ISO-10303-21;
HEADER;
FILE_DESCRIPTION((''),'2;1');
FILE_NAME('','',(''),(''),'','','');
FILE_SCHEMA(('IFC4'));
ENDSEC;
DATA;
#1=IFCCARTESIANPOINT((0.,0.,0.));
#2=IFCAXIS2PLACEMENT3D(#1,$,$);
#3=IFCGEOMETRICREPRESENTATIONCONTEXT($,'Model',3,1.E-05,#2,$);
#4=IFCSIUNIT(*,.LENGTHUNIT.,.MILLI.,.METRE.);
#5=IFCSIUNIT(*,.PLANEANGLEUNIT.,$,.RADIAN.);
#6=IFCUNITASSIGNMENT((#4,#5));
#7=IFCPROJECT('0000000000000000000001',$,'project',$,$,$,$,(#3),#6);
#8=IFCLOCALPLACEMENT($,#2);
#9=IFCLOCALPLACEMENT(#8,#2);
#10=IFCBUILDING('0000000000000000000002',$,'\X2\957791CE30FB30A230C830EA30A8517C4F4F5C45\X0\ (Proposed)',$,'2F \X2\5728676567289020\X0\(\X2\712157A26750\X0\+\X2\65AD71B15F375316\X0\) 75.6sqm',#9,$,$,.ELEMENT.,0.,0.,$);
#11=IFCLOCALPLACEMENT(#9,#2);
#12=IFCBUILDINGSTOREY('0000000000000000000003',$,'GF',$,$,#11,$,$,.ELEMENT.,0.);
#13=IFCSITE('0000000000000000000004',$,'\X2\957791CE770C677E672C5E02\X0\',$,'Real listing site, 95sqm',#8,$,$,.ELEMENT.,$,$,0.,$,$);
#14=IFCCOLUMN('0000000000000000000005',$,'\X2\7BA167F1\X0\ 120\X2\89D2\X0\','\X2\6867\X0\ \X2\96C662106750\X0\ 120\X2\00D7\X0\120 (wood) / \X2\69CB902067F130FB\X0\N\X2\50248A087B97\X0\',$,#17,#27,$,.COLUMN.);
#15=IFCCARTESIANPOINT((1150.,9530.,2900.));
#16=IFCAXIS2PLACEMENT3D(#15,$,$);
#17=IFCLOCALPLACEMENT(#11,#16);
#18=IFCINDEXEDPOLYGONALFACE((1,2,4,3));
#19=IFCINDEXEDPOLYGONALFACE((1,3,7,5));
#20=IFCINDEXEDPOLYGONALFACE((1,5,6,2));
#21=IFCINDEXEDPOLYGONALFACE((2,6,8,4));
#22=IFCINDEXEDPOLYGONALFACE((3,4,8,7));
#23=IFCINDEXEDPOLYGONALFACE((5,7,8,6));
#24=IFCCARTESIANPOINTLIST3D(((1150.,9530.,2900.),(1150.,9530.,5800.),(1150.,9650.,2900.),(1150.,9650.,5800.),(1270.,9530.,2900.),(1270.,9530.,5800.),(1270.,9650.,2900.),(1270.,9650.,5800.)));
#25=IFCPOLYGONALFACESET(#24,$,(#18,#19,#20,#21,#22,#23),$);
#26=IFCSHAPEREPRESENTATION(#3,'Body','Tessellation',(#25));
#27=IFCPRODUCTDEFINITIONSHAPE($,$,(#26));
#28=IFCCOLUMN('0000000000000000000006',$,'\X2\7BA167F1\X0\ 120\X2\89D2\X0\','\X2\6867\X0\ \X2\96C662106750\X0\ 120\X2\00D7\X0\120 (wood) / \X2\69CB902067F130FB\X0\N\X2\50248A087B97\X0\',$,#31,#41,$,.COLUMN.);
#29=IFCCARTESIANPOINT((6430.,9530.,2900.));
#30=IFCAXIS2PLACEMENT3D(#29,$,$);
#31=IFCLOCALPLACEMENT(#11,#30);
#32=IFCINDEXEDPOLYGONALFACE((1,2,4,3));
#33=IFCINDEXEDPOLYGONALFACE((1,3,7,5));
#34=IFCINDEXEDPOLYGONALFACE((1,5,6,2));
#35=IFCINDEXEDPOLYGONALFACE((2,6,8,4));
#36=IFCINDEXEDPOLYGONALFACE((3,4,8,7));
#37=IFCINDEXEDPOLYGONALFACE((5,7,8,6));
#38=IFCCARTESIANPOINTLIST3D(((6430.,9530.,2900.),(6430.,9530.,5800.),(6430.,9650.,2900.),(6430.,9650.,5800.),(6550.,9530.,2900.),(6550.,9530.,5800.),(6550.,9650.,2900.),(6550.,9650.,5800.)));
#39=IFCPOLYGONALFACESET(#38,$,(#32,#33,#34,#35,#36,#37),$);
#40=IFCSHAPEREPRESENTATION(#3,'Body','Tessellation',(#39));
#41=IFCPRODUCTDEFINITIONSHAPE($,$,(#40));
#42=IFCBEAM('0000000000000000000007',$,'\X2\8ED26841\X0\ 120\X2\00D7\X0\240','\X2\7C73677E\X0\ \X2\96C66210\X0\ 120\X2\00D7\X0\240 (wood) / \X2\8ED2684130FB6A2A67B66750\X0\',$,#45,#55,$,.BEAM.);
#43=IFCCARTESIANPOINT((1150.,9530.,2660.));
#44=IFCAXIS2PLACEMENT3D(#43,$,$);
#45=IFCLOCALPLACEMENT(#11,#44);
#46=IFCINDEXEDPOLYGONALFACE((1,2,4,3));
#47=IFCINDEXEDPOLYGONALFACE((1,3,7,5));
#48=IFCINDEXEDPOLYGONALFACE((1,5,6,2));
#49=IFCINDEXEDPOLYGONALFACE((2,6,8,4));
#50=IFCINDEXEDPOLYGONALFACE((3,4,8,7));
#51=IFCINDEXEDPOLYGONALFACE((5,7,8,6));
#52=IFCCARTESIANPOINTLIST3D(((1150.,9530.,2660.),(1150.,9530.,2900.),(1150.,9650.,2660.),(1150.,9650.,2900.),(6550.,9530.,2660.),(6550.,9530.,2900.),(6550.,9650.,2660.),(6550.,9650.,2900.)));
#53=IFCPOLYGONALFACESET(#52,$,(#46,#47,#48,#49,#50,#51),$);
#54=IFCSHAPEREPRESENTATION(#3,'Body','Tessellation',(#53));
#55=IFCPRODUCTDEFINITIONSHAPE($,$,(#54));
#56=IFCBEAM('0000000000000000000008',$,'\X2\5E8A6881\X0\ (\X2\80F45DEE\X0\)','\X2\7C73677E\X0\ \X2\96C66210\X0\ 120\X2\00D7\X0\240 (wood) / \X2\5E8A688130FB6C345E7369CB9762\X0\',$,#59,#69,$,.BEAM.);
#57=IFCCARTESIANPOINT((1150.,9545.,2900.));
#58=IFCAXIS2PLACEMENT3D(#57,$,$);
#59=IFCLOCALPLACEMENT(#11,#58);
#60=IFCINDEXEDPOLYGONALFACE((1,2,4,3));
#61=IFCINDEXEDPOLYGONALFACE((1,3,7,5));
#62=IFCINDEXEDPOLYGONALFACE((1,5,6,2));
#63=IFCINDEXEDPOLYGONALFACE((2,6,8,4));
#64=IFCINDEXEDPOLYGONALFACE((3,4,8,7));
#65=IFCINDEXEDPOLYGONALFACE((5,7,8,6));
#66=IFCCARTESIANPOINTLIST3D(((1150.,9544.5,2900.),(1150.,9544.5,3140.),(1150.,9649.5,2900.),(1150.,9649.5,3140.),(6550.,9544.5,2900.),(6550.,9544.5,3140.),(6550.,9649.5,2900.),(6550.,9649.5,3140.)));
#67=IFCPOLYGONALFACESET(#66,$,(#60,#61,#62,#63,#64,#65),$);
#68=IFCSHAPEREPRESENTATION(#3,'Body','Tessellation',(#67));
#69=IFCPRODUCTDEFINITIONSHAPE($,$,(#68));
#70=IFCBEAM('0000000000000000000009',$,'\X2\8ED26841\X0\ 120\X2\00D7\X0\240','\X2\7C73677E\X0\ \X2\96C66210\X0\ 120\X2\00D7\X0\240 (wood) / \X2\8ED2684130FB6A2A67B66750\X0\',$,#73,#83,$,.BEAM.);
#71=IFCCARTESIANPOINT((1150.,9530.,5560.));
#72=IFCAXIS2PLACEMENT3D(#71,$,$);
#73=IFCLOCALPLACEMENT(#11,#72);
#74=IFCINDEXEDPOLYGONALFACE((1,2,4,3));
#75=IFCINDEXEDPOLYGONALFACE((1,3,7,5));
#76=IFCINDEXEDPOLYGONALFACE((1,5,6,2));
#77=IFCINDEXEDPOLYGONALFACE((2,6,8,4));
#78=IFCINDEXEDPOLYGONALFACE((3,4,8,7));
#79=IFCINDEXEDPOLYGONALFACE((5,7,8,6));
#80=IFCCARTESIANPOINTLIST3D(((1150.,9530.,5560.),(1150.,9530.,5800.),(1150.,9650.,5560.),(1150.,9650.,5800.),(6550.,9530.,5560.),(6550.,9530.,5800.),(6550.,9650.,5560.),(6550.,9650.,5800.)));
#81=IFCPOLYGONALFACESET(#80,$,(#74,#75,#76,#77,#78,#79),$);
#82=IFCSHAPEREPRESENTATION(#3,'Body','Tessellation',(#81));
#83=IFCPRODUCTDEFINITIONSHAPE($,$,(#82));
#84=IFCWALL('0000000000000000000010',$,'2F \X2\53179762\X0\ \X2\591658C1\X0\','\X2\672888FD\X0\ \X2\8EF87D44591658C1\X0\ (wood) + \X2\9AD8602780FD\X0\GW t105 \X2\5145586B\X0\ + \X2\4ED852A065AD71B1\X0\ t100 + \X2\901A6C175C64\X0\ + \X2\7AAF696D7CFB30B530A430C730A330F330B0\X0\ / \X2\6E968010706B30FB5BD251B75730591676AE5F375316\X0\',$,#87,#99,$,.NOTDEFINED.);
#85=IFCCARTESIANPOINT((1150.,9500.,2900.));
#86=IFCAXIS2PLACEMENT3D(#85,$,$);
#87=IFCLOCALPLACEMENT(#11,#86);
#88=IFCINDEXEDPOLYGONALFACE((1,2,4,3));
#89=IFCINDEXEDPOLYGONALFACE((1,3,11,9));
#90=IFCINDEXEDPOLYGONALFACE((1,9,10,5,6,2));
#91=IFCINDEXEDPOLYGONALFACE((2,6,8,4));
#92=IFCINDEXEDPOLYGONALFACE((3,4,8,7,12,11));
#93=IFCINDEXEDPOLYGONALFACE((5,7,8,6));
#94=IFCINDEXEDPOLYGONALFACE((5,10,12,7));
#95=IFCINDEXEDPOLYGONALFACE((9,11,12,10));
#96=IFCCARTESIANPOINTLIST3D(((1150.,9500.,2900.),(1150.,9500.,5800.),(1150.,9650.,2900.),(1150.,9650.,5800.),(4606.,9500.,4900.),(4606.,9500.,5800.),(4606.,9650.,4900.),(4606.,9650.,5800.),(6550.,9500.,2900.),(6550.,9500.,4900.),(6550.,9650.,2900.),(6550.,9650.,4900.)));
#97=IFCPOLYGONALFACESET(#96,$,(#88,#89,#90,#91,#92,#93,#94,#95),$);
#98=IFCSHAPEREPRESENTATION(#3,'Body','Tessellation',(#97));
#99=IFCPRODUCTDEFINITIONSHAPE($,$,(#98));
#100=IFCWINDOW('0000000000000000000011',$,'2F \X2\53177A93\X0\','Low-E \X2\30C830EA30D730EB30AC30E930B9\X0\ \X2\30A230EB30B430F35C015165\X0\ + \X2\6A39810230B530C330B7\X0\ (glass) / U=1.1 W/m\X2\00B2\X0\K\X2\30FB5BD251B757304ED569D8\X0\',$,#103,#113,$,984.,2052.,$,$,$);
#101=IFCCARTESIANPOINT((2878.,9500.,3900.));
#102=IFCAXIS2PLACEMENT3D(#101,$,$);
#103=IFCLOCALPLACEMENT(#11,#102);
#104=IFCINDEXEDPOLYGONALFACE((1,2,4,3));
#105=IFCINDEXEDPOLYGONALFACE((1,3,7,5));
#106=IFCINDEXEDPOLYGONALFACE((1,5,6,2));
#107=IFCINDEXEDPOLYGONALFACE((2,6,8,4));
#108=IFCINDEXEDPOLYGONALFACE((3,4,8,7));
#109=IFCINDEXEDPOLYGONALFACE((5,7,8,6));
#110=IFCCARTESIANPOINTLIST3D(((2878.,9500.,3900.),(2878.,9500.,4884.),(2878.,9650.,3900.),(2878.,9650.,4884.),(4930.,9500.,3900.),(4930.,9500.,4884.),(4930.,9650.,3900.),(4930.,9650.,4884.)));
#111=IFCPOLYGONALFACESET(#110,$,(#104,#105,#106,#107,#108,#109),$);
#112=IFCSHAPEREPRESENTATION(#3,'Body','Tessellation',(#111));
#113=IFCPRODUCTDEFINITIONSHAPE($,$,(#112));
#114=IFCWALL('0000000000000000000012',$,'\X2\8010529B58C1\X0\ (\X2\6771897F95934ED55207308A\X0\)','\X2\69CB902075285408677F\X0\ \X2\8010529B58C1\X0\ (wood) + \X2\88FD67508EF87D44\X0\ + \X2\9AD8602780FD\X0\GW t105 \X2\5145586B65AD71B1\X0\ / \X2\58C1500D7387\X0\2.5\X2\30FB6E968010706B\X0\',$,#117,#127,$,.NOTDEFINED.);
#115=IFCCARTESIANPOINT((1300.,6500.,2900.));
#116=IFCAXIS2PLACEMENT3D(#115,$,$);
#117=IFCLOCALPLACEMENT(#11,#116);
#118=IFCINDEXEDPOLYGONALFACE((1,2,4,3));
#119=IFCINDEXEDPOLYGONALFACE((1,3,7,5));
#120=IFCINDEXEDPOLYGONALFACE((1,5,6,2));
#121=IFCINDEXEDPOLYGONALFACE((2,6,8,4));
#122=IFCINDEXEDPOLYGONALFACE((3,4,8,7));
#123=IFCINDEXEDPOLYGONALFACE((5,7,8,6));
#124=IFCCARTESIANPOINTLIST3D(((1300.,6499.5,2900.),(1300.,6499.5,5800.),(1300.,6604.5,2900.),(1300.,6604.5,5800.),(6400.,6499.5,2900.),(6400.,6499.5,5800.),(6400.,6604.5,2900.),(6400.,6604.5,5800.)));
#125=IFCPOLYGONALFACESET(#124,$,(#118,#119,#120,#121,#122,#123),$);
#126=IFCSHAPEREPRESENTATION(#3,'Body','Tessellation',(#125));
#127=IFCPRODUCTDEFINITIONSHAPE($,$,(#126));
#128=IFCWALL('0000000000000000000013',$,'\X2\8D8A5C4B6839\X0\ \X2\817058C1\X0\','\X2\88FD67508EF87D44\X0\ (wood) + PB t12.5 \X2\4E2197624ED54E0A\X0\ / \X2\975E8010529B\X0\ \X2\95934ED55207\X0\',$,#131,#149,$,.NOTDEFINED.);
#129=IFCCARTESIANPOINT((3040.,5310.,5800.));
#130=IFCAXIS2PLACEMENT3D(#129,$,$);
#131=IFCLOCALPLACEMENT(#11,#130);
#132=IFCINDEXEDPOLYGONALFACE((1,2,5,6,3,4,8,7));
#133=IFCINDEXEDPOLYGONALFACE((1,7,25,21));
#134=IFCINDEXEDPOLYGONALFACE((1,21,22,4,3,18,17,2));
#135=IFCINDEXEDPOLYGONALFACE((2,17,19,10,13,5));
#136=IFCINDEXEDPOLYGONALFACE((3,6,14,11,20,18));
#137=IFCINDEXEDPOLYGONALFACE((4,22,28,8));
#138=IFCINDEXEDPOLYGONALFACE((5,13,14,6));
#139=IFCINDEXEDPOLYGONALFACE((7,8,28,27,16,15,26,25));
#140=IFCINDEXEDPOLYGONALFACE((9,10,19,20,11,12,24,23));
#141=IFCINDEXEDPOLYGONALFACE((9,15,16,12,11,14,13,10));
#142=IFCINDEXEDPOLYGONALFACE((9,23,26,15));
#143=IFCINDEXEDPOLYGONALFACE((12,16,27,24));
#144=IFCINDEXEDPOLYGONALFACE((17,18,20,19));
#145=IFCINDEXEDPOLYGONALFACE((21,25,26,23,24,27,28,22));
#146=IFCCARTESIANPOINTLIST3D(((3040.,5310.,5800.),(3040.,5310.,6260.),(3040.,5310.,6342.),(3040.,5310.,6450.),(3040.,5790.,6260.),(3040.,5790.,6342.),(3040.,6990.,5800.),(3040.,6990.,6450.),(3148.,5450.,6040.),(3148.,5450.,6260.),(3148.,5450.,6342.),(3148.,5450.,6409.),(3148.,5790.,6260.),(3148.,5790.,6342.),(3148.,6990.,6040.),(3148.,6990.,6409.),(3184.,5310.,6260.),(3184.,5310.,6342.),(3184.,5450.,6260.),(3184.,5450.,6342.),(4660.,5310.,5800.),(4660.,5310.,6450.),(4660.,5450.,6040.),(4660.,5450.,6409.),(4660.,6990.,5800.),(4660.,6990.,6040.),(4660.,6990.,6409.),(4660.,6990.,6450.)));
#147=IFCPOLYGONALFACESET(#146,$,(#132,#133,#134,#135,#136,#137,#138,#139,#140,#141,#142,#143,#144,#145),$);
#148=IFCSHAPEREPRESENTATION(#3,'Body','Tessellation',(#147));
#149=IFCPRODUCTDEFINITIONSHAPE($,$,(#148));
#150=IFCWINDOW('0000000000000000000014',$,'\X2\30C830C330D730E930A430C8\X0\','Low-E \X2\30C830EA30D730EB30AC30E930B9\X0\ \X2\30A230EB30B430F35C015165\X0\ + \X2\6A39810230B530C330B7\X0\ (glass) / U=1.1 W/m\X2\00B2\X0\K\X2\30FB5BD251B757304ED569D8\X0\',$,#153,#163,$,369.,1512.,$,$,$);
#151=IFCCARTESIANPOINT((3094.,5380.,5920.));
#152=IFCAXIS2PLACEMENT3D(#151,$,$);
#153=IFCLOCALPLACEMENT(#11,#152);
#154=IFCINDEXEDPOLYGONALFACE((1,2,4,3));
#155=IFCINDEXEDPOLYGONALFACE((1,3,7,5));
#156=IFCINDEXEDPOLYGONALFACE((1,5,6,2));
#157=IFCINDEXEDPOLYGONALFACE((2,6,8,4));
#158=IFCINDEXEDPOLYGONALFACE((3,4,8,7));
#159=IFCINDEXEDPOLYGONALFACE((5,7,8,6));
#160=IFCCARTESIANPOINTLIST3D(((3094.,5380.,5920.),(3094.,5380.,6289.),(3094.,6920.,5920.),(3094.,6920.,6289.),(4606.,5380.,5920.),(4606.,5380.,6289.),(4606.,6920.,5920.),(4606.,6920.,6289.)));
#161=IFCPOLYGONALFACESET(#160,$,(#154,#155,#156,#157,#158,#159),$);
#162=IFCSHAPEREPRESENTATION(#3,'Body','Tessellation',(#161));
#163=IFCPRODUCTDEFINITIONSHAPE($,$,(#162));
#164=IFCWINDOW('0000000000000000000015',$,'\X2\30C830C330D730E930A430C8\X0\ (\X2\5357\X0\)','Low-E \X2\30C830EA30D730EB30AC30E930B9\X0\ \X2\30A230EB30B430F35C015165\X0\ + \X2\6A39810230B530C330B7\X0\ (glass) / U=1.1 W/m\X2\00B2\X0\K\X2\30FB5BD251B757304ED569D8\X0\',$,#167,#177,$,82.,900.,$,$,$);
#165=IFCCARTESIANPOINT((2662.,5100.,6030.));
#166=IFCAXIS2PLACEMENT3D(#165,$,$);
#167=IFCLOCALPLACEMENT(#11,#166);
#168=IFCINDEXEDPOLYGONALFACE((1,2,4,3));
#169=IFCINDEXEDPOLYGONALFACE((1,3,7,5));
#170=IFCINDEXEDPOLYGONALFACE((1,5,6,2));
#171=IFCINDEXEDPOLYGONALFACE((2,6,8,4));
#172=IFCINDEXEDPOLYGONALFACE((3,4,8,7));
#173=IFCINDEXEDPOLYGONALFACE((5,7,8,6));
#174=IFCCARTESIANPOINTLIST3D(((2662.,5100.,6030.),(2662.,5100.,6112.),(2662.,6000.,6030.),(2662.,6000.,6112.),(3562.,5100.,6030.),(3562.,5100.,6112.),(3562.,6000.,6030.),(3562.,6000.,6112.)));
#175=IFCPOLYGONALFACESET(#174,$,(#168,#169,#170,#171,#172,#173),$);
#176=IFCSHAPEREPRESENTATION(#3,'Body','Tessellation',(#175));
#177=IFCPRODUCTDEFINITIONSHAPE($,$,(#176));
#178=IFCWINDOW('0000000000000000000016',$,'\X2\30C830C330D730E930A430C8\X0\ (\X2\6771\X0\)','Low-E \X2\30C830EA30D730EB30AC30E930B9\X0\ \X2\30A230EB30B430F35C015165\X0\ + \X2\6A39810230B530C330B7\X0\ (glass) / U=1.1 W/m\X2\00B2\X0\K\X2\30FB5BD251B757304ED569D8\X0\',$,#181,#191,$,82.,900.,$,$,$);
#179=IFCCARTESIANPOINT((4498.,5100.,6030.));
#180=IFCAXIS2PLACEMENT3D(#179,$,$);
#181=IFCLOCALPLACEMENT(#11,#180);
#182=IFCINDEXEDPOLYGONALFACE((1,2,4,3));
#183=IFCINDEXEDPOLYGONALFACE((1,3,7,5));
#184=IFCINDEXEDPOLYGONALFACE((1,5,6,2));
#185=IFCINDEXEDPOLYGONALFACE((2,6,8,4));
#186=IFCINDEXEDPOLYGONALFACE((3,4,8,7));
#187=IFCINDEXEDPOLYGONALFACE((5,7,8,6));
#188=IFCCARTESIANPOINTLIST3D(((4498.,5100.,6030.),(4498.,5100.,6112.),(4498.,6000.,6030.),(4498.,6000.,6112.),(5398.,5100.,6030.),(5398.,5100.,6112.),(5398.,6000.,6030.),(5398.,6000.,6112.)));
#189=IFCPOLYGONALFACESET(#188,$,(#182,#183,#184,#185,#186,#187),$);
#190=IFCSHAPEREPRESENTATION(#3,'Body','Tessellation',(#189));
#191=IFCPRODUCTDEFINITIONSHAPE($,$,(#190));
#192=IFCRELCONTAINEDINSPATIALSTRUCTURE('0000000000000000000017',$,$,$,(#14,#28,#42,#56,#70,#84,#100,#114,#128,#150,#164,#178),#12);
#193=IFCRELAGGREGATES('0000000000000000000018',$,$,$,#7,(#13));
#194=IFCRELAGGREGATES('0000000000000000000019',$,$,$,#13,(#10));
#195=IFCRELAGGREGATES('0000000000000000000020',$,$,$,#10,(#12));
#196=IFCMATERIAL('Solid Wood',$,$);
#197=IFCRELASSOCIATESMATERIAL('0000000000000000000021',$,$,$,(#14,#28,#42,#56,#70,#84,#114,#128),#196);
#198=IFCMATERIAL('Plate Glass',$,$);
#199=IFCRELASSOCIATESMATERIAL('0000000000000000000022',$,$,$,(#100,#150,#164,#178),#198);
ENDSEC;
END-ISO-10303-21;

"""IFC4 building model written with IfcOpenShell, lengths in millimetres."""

from ifc_helpers import new_model, si_unit, frame, frame_2d, origin, place, context, project, spatial, rectangle, extrude, material, element, fill, save


model = new_model("IFC4")

# Units and contexts
model_context = context("Model", 3, precision=1e-05, world=origin())
ifc_project = project(units=[si_unit("LENGTHUNIT", "METRE", prefix="MILLI"), si_unit("PLANEANGLEUNIT", "RADIAN")], contexts=[model_context])

# Site, building, storey
site_placement = place(None, origin())
site = spatial("IfcSite", under=ifc_project, at=site_placement, Name="長野県松本市", ObjectType="Real listing site, 95sqm", CompositionType="ELEMENT", RefElevation=0.0)
building_placement = place(site_placement, origin())
building = spatial("IfcBuilding", under=site, at=building_placement, Name="長野・アトリエ兼住居 (Proposed)", ObjectType="2F 在来木造(無垢材+断熱強化) 75.6sqm", CompositionType="ELEMENT", ElevationOfRefHeight=0.0, ElevationOfTerrain=0.0)
storey_placement = place(building_placement, origin())
storey = spatial("IfcBuildingStorey", under=building, at=storey_placement, Name="GF", CompositionType="ELEMENT", Elevation=0.0)

# Columns
ifc_material_1 = material(Name="Solid Wood")
column_1_placement = place(storey_placement, frame((1150.0, 9530.0, 2900.0)))
element("IfcColumn", 1, at=column_1_placement, inside=storey, material=ifc_material_1, Name="管柱 120角", Description="桧 集成材 120×120 (wood) / 構造柱・N値計算", PredefinedType="COLUMN", context=model_context, shape_type="SweptSolid", body=[
    extrude(rectangle(XDim=120.0, YDim=120.0, at=frame_2d((60.0, 60.0))), frame((1150.0, 9530.0, 2900.0)), (0.0, 0.0, 1.0), 2900.0),
])
column_2_placement = place(storey_placement, frame((6430.0, 9530.0, 2900.0)))
element("IfcColumn", 2, at=column_2_placement, inside=storey, material=ifc_material_1, Name="管柱 120角", Description="桧 集成材 120×120 (wood) / 構造柱・N値計算", PredefinedType="COLUMN", context=model_context, shape_type="SweptSolid", body=[
    extrude(rectangle(XDim=120.0, YDim=120.0, at=frame_2d((60.0, 60.0))), frame((6430.0, 9530.0, 2900.0)), (0.0, 0.0, 1.0), 2900.0),
])

# Beams
beam_1_placement = place(storey_placement, frame((1150.0, 9530.0, 2660.0)))
element("IfcBeam", 3, at=beam_1_placement, inside=storey, material=ifc_material_1, Name="軒桁 120×240", Description="米松 集成 120×240 (wood) / 軒桁・横架材", PredefinedType="BEAM", context=model_context, shape_type="SweptSolid", body=[
    extrude(rectangle(XDim=5400.0, YDim=120.0, at=frame_2d((2700.0, 60.0))), frame((1150.0, 9530.0, 2660.0)), (0.0, 0.0, 1.0), 240.0),
])
beam_2_placement = place(storey_placement, frame((1150.0, 9545.0, 2900.0)))
element("IfcBeam", 4, at=beam_2_placement, inside=storey, material=ifc_material_1, Name="床梁 (胴差)", Description="米松 集成 120×240 (wood) / 床梁・水平構面", PredefinedType="BEAM", context=model_context, shape_type="SweptSolid", body=[
    extrude(rectangle(XDim=5400.0, YDim=105.0, at=frame_2d((2700.0, 52.0))), frame((1150.0, 9545.0, 2900.0)), (0.0, 0.0, 1.0), 240.0),
])
beam_3_placement = place(storey_placement, frame((1150.0, 9530.0, 5560.0)))
element("IfcBeam", 5, at=beam_3_placement, inside=storey, material=ifc_material_1, Name="軒桁 120×240", Description="米松 集成 120×240 (wood) / 軒桁・横架材", PredefinedType="BEAM", context=model_context, shape_type="SweptSolid", body=[
    extrude(rectangle(XDim=5400.0, YDim=120.0, at=frame_2d((2700.0, 60.0))), frame((1150.0, 9530.0, 5560.0)), (0.0, 0.0, 1.0), 240.0),
])

# Wall, opening, window
wall_1_placement = place(storey_placement, frame((1150.0, 9500.0, 2900.0)))
wall_1 = element("IfcWall", 6, at=wall_1_placement, inside=storey, material=ifc_material_1, Name="2F 北面 外壁", Description="木製 軸組外壁 (wood) + 高性能GW t105 充填 + 付加断熱 t100 + 通気層 + 窯業系サイディング / 準耐火・寒冷地外皮強化", PredefinedType="NOTDEFINED", context=model_context, shape_type="SweptSolid", body=[
    extrude(rectangle(XDim=5400.0, YDim=150.0, at=frame_2d((2700.0, 75.0))), frame((1150.0, 9500.0, 2900.0)), (0.0, 0.0, 1.0), 2900.0),
])
opening_1_placement = place(storey_placement, frame((2878.0, 9500.0, 3900.0)))
opening_1 = element("IfcOpeningElement", 7, at=opening_1_placement, cuts=wall_1, PredefinedType="NOTDEFINED", context=model_context, shape_type="SweptSolid", body=[
    extrude(rectangle(XDim=2052.0, YDim=150.0, at=frame_2d((1026.0, 75.0))), frame((2878.0, 9500.0, 3900.0)), (0.0, 0.0, 1.0), 984.0),
])
ifc_material_2 = material(Name="Plate Glass")
window_1_placement = place(storey_placement, frame((2878.0, 9500.0, 3900.0)))
window_1 = element("IfcWindow", 8, at=window_1_placement, inside=storey, material=ifc_material_2, Name="2F 北窓", Description="Low-E トリプルガラス アルゴン封入 + 樹脂サッシ (glass) / U=1.1 W/m²K・寒冷地仕様", OverallHeight=984.0, OverallWidth=2052.0, context=model_context, shape_type="SweptSolid", body=[
    extrude(rectangle(XDim=2052.0, YDim=150.0, at=frame_2d((1026.0, 75.0))), frame((2878.0, 9500.0, 3900.0)), (0.0, 0.0, 1.0), 984.0),
])
fill(opening_1, window_1)

# Wall
wall_2_placement = place(storey_placement, frame((1300.0, 6500.0, 2900.0)))
element("IfcWall", 9, at=wall_2_placement, inside=storey, material=ifc_material_1, Name="耐力壁 (東西間仕切り)", Description="構造用合板 耐力壁 (wood) + 製材軸組 + 高性能GW t105 充填断熱 / 壁倍率2.5・準耐火", PredefinedType="NOTDEFINED", context=model_context, shape_type="SweptSolid", body=[
    extrude(rectangle(XDim=5100.0, YDim=105.0, at=frame_2d((2550.0, 52.0))), frame((1300.0, 6500.0, 2900.0)), (0.0, 0.0, 1.0), 2900.0),
])

# Wall, openings, windows
wall_3_placement = place(storey_placement, frame((3040.0, 5310.0, 5800.0)))
wall_3 = element("IfcWall", 10, at=wall_3_placement, inside=storey, material=ifc_material_1, Name="越屋根 腰壁", Description="製材軸組 (wood) + PB t12.5 両面仕上 / 非耐力 間仕切", PredefinedType="NOTDEFINED", context=model_context, shape_type="SweptSolid", body=[
    extrude(rectangle(XDim=1620.0, YDim=1680.0, at=frame_2d((810.0, 840.0))), frame((3040.0, 5310.0, 5800.0)), (0.0, 0.0, 1.0), 650.0),
])
opening_2_placement = place(storey_placement, frame((3094.0, 5380.0, 5920.0)))
opening_2 = element("IfcOpeningElement", 11, at=opening_2_placement, cuts=wall_3, PredefinedType="NOTDEFINED", context=model_context, shape_type="SweptSolid", body=[
    extrude(rectangle(XDim=1512.0, YDim=1540.0, at=frame_2d((756.0, 770.0))), frame((3094.0, 5380.0, 5920.0)), (0.0, 0.0, 1.0), 369.0),
])
opening_3_placement = place(storey_placement, frame((2662.0, 5100.0, 6030.0)))
opening_3 = element("IfcOpeningElement", 12, at=opening_3_placement, cuts=wall_3, PredefinedType="NOTDEFINED", context=model_context, shape_type="SweptSolid", body=[
    extrude(rectangle(XDim=900.0, YDim=900.0, at=frame_2d((450.0, 450.0))), frame((2662.0, 5100.0, 6030.0)), (0.0, 0.0, 1.0), 82.0),
])
opening_4_placement = place(storey_placement, frame((4498.0, 5100.0, 6030.0)))
opening_4 = element("IfcOpeningElement", 13, at=opening_4_placement, cuts=wall_3, PredefinedType="NOTDEFINED", context=model_context, shape_type="SweptSolid", body=[
    extrude(rectangle(XDim=900.0, YDim=900.0, at=frame_2d((450.0, 450.0))), frame((4498.0, 5100.0, 6030.0)), (0.0, 0.0, 1.0), 82.0),
])
window_2_placement = place(storey_placement, frame((3094.0, 5380.0, 5920.0)))
window_2 = element("IfcWindow", 14, at=window_2_placement, inside=storey, material=ifc_material_2, Name="トップライト", Description="Low-E トリプルガラス アルゴン封入 + 樹脂サッシ (glass) / U=1.1 W/m²K・寒冷地仕様", OverallHeight=369.0, OverallWidth=1512.0, context=model_context, shape_type="SweptSolid", body=[
    extrude(rectangle(XDim=1512.0, YDim=1540.0, at=frame_2d((756.0, 770.0))), frame((3094.0, 5380.0, 5920.0)), (0.0, 0.0, 1.0), 369.0),
])
fill(opening_2, window_2)
window_3_placement = place(storey_placement, frame((2662.0, 5100.0, 6030.0)))
window_3 = element("IfcWindow", 15, at=window_3_placement, inside=storey, material=ifc_material_2, Name="トップライト (南)", Description="Low-E トリプルガラス アルゴン封入 + 樹脂サッシ (glass) / U=1.1 W/m²K・寒冷地仕様", OverallHeight=82.0, OverallWidth=900.0, context=model_context, shape_type="SweptSolid", body=[
    extrude(rectangle(XDim=900.0, YDim=900.0, at=frame_2d((450.0, 450.0))), frame((2662.0, 5100.0, 6030.0)), (0.0, 0.0, 1.0), 82.0),
])
fill(opening_3, window_3)
window_4_placement = place(storey_placement, frame((4498.0, 5100.0, 6030.0)))
window_4 = element("IfcWindow", 16, at=window_4_placement, inside=storey, material=ifc_material_2, Name="トップライト (東)", Description="Low-E トリプルガラス アルゴン封入 + 樹脂サッシ (glass) / U=1.1 W/m²K・寒冷地仕様", OverallHeight=82.0, OverallWidth=900.0, context=model_context, shape_type="SweptSolid", body=[
    extrude(rectangle(XDim=900.0, YDim=900.0, at=frame_2d((450.0, 450.0))), frame((4498.0, 5100.0, 6030.0)), (0.0, 0.0, 1.0), 82.0),
])
fill(opening_4, window_4)

save(model, "model.ifc")
